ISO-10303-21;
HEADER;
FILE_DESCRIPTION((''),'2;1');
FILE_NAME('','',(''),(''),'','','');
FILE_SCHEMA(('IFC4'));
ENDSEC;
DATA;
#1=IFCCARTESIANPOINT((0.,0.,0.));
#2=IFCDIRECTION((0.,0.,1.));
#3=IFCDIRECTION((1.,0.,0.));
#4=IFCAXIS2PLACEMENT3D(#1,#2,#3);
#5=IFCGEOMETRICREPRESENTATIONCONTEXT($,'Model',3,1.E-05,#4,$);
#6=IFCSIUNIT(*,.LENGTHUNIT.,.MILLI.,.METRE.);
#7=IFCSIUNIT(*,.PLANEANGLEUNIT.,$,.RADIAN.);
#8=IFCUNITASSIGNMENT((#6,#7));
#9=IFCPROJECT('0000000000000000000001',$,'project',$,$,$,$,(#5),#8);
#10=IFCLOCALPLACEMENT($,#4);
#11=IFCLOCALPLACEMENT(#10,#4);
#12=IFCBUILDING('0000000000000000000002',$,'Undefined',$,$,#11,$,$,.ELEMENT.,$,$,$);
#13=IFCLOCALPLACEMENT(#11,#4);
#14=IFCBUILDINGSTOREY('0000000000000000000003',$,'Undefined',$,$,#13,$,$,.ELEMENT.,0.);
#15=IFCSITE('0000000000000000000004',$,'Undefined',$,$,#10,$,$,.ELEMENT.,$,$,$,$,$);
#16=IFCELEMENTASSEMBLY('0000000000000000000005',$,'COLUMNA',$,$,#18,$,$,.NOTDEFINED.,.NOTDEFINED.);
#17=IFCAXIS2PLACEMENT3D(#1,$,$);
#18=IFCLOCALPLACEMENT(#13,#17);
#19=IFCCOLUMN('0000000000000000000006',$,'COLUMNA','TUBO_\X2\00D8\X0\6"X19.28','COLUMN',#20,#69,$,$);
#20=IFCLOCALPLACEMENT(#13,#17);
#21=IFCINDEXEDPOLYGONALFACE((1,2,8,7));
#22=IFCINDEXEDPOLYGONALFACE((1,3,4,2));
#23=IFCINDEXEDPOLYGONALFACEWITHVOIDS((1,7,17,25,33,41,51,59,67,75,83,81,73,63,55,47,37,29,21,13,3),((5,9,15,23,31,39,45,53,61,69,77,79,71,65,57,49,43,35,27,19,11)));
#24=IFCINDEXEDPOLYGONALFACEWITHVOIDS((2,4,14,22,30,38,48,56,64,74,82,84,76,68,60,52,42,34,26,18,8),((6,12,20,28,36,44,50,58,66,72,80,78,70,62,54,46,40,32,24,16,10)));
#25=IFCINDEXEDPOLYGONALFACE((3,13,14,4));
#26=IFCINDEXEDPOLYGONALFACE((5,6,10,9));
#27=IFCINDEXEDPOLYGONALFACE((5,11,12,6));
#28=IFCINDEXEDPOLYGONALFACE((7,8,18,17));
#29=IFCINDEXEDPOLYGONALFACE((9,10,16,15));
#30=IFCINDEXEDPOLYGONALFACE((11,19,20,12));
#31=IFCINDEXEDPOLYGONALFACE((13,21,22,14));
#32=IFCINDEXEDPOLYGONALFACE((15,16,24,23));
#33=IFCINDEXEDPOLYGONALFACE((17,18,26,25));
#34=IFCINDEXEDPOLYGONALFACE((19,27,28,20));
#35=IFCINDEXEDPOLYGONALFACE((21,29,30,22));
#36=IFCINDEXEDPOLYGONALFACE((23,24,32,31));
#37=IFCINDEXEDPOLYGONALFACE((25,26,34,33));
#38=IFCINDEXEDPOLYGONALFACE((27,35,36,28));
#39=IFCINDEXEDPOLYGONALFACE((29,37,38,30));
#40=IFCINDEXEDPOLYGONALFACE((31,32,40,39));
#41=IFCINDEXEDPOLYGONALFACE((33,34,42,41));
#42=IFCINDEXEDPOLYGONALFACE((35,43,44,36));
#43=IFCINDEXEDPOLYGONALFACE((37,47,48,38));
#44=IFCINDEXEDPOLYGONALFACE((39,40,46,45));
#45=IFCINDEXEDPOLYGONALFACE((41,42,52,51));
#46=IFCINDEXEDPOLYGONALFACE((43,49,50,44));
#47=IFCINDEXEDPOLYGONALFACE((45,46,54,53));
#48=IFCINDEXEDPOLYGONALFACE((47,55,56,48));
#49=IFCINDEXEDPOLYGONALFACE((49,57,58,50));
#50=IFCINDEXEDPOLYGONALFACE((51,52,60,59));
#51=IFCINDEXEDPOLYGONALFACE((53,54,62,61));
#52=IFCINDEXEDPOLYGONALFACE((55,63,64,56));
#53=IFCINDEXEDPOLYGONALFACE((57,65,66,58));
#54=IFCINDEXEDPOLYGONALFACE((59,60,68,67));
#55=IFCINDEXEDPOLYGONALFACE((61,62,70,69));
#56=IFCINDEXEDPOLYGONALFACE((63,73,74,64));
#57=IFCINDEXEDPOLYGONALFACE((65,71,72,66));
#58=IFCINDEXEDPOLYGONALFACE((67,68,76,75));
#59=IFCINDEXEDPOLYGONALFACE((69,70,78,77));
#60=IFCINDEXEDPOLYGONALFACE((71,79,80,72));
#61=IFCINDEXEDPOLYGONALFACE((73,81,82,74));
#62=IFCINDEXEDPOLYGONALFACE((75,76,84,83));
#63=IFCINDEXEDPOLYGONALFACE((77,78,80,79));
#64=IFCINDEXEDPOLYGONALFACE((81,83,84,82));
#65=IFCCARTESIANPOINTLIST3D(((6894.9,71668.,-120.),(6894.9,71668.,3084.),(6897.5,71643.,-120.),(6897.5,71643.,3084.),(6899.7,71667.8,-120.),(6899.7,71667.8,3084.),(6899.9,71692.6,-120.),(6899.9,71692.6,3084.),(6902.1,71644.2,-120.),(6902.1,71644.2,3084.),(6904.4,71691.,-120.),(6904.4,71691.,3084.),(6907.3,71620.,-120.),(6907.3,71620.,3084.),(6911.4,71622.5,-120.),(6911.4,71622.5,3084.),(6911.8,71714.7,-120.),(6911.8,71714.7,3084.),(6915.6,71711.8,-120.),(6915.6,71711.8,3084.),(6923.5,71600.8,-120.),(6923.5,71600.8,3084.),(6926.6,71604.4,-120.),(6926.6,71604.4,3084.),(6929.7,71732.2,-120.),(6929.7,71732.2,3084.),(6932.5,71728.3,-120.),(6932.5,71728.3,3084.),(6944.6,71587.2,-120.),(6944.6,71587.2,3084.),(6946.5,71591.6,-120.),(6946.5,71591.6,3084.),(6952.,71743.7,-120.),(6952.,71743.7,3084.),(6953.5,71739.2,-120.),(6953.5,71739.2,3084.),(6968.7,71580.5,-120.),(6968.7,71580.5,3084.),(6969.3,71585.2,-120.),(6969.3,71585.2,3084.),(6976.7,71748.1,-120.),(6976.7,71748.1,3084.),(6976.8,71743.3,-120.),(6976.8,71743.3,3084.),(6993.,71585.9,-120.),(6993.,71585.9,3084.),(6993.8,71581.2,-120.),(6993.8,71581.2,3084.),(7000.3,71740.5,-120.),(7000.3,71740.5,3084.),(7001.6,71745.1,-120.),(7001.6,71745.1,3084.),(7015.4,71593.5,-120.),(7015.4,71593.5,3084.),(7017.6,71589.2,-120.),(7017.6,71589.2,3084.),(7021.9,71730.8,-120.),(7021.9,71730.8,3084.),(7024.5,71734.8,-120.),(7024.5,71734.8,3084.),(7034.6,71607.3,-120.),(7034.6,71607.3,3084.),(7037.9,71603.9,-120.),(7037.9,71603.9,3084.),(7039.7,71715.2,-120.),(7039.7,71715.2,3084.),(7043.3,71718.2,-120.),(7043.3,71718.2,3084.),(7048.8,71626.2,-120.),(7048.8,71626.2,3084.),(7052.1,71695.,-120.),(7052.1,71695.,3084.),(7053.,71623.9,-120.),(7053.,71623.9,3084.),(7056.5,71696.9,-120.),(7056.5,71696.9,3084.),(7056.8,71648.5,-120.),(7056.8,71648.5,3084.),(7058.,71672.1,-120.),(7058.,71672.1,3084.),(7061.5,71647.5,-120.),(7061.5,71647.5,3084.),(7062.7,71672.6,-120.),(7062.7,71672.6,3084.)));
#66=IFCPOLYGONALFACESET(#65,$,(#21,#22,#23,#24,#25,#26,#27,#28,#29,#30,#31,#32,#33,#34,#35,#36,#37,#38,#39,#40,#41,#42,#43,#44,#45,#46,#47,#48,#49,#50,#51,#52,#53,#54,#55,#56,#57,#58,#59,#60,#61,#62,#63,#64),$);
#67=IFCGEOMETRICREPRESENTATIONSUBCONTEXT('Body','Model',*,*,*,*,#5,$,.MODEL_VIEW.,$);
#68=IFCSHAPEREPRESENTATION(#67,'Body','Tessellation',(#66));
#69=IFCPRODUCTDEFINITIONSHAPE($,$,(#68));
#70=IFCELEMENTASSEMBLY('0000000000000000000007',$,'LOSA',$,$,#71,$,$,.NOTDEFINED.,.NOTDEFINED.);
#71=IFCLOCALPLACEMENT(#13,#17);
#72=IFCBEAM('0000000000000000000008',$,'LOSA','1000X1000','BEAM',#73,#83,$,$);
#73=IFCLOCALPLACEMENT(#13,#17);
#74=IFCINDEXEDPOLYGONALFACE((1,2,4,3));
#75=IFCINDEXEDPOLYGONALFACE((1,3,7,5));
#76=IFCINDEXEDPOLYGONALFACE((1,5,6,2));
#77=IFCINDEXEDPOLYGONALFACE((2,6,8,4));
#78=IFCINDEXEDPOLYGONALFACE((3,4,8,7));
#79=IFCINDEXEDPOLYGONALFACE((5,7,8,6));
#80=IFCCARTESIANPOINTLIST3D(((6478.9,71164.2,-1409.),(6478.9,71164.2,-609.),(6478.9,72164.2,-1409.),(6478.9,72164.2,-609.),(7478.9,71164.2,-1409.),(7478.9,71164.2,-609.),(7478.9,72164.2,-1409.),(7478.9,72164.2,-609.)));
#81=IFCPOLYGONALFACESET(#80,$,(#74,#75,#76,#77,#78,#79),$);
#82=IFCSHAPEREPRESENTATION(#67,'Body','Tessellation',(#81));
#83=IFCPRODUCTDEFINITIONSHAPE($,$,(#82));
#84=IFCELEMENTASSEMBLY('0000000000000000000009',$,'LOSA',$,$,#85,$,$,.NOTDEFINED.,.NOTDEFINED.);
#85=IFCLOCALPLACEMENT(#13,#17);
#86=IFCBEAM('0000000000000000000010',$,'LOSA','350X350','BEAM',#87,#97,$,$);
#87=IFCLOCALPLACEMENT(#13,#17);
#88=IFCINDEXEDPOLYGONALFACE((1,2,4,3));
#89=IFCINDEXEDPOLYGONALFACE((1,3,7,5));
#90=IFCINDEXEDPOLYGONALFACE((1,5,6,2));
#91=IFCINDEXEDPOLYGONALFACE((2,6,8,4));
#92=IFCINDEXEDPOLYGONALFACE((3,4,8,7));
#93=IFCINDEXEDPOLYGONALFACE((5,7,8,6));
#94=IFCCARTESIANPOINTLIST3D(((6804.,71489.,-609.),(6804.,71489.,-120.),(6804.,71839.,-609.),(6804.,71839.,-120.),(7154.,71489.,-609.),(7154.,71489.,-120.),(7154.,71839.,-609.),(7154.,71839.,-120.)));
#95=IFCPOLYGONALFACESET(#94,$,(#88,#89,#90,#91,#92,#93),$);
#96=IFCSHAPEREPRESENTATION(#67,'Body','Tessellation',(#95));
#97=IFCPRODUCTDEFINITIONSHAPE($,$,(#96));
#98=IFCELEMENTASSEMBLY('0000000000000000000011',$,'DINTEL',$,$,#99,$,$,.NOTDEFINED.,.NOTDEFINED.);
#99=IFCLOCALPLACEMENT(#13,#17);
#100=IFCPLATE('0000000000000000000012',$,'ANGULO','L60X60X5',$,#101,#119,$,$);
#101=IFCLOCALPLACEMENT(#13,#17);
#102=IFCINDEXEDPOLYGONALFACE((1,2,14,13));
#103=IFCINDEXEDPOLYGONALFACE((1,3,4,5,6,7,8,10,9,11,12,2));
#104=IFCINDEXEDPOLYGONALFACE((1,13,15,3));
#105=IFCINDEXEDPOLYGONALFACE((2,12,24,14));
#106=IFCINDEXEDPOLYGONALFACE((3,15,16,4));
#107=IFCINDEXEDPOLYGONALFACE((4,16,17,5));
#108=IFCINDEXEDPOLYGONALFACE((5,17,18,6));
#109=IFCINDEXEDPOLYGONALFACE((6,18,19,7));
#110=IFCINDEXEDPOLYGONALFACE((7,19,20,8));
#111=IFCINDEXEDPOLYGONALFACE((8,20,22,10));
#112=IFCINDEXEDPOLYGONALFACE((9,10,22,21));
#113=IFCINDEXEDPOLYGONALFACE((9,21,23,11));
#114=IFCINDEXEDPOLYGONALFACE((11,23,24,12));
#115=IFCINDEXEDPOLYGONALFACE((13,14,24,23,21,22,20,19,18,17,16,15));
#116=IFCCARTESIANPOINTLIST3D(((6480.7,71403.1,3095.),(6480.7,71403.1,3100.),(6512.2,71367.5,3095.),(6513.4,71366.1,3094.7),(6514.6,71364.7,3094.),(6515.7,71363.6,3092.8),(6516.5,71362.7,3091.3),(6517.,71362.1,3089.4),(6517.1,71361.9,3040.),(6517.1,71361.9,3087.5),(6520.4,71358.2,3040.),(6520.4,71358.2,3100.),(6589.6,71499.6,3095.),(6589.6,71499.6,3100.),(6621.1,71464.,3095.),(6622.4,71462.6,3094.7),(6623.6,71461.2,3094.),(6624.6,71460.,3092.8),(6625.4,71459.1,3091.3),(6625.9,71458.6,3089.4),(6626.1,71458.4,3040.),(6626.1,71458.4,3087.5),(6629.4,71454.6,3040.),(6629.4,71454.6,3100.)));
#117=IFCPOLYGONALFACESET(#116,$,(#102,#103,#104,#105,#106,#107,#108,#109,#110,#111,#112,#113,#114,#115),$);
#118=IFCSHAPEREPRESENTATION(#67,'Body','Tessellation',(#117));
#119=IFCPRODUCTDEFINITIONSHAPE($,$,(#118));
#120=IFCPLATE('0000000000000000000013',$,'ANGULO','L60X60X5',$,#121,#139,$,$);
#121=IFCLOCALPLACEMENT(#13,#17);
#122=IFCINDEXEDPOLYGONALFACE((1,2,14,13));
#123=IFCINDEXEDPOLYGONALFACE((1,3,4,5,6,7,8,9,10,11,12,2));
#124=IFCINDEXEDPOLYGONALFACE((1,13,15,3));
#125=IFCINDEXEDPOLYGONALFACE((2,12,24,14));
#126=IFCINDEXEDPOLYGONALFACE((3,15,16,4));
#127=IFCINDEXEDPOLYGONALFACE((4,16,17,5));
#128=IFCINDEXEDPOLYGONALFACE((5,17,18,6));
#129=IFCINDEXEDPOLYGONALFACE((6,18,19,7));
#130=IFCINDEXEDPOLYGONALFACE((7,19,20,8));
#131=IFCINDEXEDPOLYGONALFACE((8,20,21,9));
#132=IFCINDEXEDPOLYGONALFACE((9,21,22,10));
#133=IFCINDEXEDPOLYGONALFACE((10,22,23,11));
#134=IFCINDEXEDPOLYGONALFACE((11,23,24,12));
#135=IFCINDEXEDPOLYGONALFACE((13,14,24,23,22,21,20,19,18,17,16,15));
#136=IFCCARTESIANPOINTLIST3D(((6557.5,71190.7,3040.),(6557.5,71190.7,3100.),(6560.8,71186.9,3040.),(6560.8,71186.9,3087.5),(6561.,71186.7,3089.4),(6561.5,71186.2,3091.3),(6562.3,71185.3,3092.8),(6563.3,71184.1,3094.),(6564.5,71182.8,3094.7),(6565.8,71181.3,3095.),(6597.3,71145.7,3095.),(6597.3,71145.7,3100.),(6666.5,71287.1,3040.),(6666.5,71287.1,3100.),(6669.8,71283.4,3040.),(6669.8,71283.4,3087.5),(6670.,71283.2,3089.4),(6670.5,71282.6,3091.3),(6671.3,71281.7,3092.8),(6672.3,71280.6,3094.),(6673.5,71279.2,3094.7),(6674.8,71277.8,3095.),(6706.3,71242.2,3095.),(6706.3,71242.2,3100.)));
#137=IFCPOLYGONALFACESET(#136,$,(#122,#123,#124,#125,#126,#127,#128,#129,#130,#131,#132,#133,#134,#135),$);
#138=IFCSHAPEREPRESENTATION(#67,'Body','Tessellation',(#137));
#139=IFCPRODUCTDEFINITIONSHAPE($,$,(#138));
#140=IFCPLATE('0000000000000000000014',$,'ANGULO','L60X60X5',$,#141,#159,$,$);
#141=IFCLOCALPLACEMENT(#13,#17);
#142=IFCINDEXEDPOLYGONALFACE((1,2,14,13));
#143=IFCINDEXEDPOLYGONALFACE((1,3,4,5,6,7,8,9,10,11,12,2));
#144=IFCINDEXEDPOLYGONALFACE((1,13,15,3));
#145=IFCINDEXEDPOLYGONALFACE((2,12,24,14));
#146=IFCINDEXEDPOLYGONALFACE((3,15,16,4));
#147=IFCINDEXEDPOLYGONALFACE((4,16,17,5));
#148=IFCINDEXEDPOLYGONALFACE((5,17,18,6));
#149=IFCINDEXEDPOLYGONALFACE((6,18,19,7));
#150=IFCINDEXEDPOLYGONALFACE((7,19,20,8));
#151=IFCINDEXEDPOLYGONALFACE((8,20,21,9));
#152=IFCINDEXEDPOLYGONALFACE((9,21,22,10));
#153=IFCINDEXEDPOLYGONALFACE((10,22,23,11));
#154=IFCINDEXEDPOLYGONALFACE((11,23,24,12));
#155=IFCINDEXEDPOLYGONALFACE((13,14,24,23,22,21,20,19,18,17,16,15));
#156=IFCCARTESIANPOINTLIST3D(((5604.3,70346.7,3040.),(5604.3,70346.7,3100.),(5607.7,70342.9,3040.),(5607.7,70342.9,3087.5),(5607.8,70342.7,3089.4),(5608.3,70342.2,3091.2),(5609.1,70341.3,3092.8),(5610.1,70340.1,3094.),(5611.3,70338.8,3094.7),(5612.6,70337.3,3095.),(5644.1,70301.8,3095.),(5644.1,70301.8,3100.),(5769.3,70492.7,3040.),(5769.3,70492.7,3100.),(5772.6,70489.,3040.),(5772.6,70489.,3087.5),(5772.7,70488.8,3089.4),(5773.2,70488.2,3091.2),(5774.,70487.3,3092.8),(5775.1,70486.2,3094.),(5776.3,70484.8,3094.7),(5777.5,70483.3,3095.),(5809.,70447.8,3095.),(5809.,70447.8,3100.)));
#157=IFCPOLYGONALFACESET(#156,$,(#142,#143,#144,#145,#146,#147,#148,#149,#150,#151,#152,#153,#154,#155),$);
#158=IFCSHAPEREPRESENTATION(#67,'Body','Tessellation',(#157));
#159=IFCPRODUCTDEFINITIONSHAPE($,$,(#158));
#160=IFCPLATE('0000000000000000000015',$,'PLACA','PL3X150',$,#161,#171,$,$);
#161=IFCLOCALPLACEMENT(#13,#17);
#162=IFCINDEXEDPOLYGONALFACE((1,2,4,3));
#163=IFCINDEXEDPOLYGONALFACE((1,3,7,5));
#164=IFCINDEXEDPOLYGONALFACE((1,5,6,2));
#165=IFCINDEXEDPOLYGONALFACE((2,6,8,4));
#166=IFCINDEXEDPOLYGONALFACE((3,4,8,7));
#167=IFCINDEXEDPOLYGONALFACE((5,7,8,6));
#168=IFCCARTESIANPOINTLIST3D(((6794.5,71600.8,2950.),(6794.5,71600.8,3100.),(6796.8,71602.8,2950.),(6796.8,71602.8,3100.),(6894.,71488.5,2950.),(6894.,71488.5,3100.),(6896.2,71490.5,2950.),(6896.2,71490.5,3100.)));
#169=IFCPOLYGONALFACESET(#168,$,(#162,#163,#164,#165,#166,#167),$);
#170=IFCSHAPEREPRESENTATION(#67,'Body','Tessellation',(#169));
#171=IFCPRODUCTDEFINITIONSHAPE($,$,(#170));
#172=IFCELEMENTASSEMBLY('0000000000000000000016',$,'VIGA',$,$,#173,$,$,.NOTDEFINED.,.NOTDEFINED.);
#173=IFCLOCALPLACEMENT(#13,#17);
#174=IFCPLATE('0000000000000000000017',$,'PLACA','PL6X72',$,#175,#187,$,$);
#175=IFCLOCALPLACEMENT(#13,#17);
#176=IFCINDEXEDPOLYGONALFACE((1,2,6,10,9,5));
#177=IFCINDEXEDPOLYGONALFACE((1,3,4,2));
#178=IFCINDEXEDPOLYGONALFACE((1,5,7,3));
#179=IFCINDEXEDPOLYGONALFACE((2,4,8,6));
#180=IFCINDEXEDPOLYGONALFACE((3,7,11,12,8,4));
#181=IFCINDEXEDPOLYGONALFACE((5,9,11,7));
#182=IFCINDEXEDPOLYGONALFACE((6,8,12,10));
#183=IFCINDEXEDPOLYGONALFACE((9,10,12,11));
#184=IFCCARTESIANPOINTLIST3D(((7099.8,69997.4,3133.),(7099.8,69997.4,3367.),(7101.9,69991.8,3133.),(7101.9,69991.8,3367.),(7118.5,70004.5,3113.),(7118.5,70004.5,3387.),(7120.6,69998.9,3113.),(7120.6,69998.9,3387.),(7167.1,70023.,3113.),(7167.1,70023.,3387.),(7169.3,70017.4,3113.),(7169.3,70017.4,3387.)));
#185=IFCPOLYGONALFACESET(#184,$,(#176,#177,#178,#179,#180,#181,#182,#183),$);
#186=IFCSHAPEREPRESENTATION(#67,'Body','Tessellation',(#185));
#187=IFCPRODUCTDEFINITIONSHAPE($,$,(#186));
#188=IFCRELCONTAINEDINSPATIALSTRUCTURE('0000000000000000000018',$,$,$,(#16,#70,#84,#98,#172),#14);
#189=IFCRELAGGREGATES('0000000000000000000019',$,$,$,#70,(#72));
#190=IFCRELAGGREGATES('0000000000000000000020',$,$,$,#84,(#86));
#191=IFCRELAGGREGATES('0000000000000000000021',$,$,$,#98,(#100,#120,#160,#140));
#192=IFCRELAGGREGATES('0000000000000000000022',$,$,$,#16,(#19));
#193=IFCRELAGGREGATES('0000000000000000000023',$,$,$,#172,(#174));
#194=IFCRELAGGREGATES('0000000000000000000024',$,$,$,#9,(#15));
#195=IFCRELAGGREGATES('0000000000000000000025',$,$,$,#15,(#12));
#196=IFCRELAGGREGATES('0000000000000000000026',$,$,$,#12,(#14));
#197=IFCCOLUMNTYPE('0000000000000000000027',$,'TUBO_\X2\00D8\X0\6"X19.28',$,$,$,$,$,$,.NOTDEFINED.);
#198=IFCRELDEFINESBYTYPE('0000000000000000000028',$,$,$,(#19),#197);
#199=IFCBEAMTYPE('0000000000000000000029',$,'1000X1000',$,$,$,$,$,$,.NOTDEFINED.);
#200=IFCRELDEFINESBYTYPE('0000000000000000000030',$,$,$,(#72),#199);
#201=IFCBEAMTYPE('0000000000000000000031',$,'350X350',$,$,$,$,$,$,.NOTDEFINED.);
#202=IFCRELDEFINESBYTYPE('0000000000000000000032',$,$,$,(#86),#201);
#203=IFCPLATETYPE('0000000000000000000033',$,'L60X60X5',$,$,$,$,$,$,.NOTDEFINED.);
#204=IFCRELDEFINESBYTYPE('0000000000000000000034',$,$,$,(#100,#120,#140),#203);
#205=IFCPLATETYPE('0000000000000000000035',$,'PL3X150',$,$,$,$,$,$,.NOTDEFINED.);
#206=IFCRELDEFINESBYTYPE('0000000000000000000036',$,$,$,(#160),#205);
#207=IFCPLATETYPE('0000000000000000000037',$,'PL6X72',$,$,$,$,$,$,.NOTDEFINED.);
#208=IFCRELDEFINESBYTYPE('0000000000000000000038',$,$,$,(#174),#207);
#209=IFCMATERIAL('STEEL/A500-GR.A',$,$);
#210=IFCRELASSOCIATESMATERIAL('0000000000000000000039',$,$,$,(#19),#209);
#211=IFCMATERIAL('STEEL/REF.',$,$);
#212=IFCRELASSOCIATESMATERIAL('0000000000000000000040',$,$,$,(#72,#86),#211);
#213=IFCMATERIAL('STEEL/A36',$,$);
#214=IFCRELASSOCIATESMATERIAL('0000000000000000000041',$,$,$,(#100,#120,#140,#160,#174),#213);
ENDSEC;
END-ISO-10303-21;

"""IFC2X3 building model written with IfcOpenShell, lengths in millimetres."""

from ifc_helpers import new_model, si_unit, frame, origin_with_axes, origin_2d_with_axis, place, context, subcontext, project, spatial, polyline, rectangle, hollow_circle, l_section, outline, extrude, clip, halfspace, material, type_object, element, aggregate, save


model = new_model("IFC2X3")

# Units and contexts
model_context = context("Model", 3, precision=1e-05, world=origin_with_axes())
body_context = subcontext(model_context, "Body", "Model", "MODEL_VIEW")
ifc_project = project(units=[si_unit("LENGTHUNIT", "METRE", prefix="MILLI"), si_unit("PLANEANGLEUNIT", "RADIAN")], contexts=[model_context])

# Site, building, storey
site_placement = place(None, origin_with_axes())
site = spatial("IfcSite", under=ifc_project, at=site_placement, Name="Undefined", CompositionType="ELEMENT")
building_placement = place(site_placement, origin_with_axes())
building = spatial("IfcBuilding", under=site, at=building_placement, Name="Undefined", CompositionType="ELEMENT")
storey_placement = place(building_placement, origin_with_axes())
storey = spatial("IfcBuildingStorey", under=building, at=storey_placement, Name="Undefined", CompositionType="ELEMENT", Elevation=0.0)

# Element assembly, column
assembly_1_placement = place(storey_placement, origin_with_axes())
assembly_1 = element("IfcElementAssembly", 1, at=assembly_1_placement, inside=storey, Name="COLUMNA", AssemblyPlace="NOTDEFINED", PredefinedType="NOTDEFINED")
ifc_material_1 = material(Name="STEEL/A500-GR.A")
column_type = type_object("IfcColumnType", Name="TUBO_Ø6\"X19.28", PredefinedType="NOTDEFINED")
column_placement = place(assembly_1_placement, frame((6979.0, 71664.0, -120.0), z_axis=(0.0, 0.0, 1.0), x_axis=(-0.912465, 0.409155, 0.0)))
column = element("IfcColumn", 2, at=column_placement, type_object=column_type, material=ifc_material_1, Name="COLUMNA", Description="TUBO_Ø6\"X19.28", ObjectType="COLUMN", context=body_context, shape_type="Clipping", body=[
    clip(extrude(hollow_circle(Radius=84.2, WallThickness=4.8, at=origin_2d_with_axis()), frame((0.0, 0.0, 3220.0), z_axis=(0.0, 0.0, -1.0), x_axis=(0.0, 1.0, 0.0)), (0.0, 0.0, 1.0), 3220.0), halfspace(frame((0.0, 84.1, 3204.0), z_axis=(0.0, 0.0, -1.0), x_axis=(-1.0, 0.0, 0.0)), True)),
])

# Element assemblies, beams
assembly_2_placement = place(storey_placement, origin_with_axes())
assembly_2 = element("IfcElementAssembly", 3, at=assembly_2_placement, inside=storey, Name="LOSA", AssemblyPlace="NOTDEFINED", PredefinedType="NOTDEFINED")
ifc_material_2 = material(Name="STEEL/REF.")
beam_type_1 = type_object("IfcBeamType", Name="1000X1000", PredefinedType="NOTDEFINED")
beam_1_placement = place(assembly_2_placement, frame((6978.9, 71664.2, -609.0), z_axis=(1.0, 0.0, 0.0), x_axis=(0.0, 0.0, -1.0)))
beam_1 = element("IfcBeam", 4, at=beam_1_placement, type_object=beam_type_1, material=ifc_material_2, Name="LOSA", Description="1000X1000", ObjectType="BEAM", context=body_context, shape_type="SweptSolid", body=[
    extrude(rectangle(XDim=1000.0, YDim=1000.0, at=origin_2d_with_axis()), frame((800.0, 0.0, 0.0), z_axis=(-1.0, 0.0, 0.0), x_axis=(0.0, -1.0, 0.0)), (0.0, 0.0, 1.0), 800.0),
])
aggregate(assembly_2, [beam_1])
assembly_3_placement = place(storey_placement, origin_with_axes())
assembly_3 = element("IfcElementAssembly", 5, at=assembly_3_placement, inside=storey, Name="LOSA", AssemblyPlace="NOTDEFINED", PredefinedType="NOTDEFINED")
beam_type_2 = type_object("IfcBeamType", Name="350X350", PredefinedType="NOTDEFINED")
beam_2_placement = place(assembly_3_placement, frame((6979.0, 71664.0, -120.0), z_axis=(1.0, 0.0, 0.0), x_axis=(0.0, 0.0, -1.0)))
beam_2 = element("IfcBeam", 6, at=beam_2_placement, type_object=beam_type_2, material=ifc_material_2, Name="LOSA", Description="350X350", ObjectType="BEAM", context=body_context, shape_type="SweptSolid", body=[
    extrude(rectangle(XDim=350.0, YDim=350.0, at=origin_2d_with_axis()), frame((489.0, 0.0, 0.0), z_axis=(-1.0, 0.0, 0.0), x_axis=(0.0, -1.0, 0.0)), (0.0, 0.0, 1.0), 489.0),
])
aggregate(assembly_3, [beam_2])

# Element assembly, plates
assembly_4_placement = place(storey_placement, origin_with_axes())
assembly_4 = element("IfcElementAssembly", 7, at=assembly_4_placement, inside=storey, Name="DINTEL", AssemblyPlace="NOTDEFINED", PredefinedType="NOTDEFINED")
ifc_material_3 = material(Name="STEEL/A36")
plate_type_1 = type_object("IfcPlateType", Name="L60X60X5", PredefinedType="NOTDEFINED")
plate_1_placement = place(assembly_4_placement, frame((6500.6, 71380.6, 3070.0), z_axis=(0.0, 0.0, -1.0), x_axis=(0.748701, 0.662908, 0.0)))
plate_1 = element("IfcPlate", 8, at=plate_1_placement, type_object=plate_type_1, material=ifc_material_3, Name="ANGULO", Description="L60X60X5", context=body_context, shape_type="SweptSolid", body=[
    extrude(l_section(Depth=60.0, Width=60.0, Thickness=5.0, FilletRadius=7.5, at=origin_2d_with_axis()), frame((145.5, 0.0, 0.0), z_axis=(-1.0, 0.0, 0.0), x_axis=(0.0, -1.0, 0.0)), (0.0, 0.0, 1.0), 145.5),
])
plate_2_placement = place(assembly_4_placement, frame((6686.4, 71264.7, 3070.0), z_axis=(0.0, 0.0, -1.0), x_axis=(-0.748701, -0.662908, 0.0)))
plate_2 = element("IfcPlate", 9, at=plate_2_placement, type_object=plate_type_1, material=ifc_material_3, Name="ANGULO", Description="L60X60X5", context=body_context, shape_type="SweptSolid", body=[
    extrude(l_section(Depth=60.0, Width=60.0, Thickness=5.0, FilletRadius=7.5, at=origin_2d_with_axis()), frame((145.5, 0.0, 0.0), z_axis=(-1.0, 0.0, 0.0), x_axis=(0.0, -1.0, 0.0)), (0.0, 0.0, 1.0), 145.5),
])
plate_3_placement = place(assembly_4_placement, frame((5789.1, 70470.2, 3070.0), z_axis=(0.0, 0.0, -1.0), x_axis=(-0.748701, -0.662908, 0.0)))
plate_3 = element("IfcPlate", 10, at=plate_3_placement, type_object=plate_type_1, material=ifc_material_3, Name="ANGULO", Description="L60X60X5", context=body_context, shape_type="SweptSolid", body=[
    extrude(l_section(Depth=60.0, Width=60.0, Thickness=5.0, FilletRadius=7.5, at=origin_2d_with_axis()), frame((220.3, 0.0, 0.0), z_axis=(-1.0, 0.0, 0.0), x_axis=(0.0, -1.0, 0.0)), (0.0, 0.0, 1.0), 220.3),
])
plate_type_2 = type_object("IfcPlateType", Name="PL3X150", PredefinedType="NOTDEFINED")
plate_4_placement = place(assembly_4_placement, frame((6795.6, 71601.8, 2950.0), z_axis=(-0.7487, -0.662909, 0.0), x_axis=(0.662909, -0.7487, 0.0)))
plate_4 = element("IfcPlate", 11, at=plate_4_placement, type_object=plate_type_2, material=ifc_material_3, Name="PLACA", Description="PL3X150", context=body_context, shape_type="SweptSolid", body=[
    extrude(outline(polyline([(0.0, 0.0), (150.0, 0.0), (150.0, 150.0), (0.0, 150.0), (0.0, 0.0)])), frame((0.0, 0.0, -1.5), z_axis=(0.0, 0.0, 1.0), x_axis=(1.0, 0.0, 0.0)), (0.0, 0.0, 1.0), 3.0),
])
aggregate(assembly_4, [plate_1, plate_2, plate_4, plate_3])

# Element assembly, plate
assembly_5_placement = place(storey_placement, origin_with_axes())
assembly_5 = element("IfcElementAssembly", 12, at=assembly_5_placement, inside=storey, Name="VIGA", AssemblyPlace="NOTDEFINED", PredefinedType="NOTDEFINED")
plate_type_3 = type_object("IfcPlateType", Name="PL6X72", PredefinedType="NOTDEFINED")
plate_5_placement = place(assembly_5_placement, frame((7168.2, 70020.2, 3113.0), z_axis=(-0.354934, 0.934891, 0.0), x_axis=(-0.934891, -0.354934, 0.0)))
plate_5 = element("IfcPlate", 13, at=plate_5_placement, type_object=plate_type_3, material=ifc_material_3, Name="PLACA", Description="PL6X72", context=body_context, shape_type="SweptSolid", body=[
    extrude(outline(polyline([(0.0, 0.0), (52.0, 0.0), (72.0, 20.0), (72.0, 254.0), (52.0, 274.0), (0.0, 274.0), (0.0, 0.0)])), frame((0.0, 0.0, -3.0), z_axis=(0.0, 0.0, 1.0), x_axis=(1.0, 0.0, 0.0)), (0.0, 0.0, 1.0), 6.0),
])

aggregate(assembly_1, [column])

aggregate(assembly_5, [plate_5])

save(model, "model.ifc")
